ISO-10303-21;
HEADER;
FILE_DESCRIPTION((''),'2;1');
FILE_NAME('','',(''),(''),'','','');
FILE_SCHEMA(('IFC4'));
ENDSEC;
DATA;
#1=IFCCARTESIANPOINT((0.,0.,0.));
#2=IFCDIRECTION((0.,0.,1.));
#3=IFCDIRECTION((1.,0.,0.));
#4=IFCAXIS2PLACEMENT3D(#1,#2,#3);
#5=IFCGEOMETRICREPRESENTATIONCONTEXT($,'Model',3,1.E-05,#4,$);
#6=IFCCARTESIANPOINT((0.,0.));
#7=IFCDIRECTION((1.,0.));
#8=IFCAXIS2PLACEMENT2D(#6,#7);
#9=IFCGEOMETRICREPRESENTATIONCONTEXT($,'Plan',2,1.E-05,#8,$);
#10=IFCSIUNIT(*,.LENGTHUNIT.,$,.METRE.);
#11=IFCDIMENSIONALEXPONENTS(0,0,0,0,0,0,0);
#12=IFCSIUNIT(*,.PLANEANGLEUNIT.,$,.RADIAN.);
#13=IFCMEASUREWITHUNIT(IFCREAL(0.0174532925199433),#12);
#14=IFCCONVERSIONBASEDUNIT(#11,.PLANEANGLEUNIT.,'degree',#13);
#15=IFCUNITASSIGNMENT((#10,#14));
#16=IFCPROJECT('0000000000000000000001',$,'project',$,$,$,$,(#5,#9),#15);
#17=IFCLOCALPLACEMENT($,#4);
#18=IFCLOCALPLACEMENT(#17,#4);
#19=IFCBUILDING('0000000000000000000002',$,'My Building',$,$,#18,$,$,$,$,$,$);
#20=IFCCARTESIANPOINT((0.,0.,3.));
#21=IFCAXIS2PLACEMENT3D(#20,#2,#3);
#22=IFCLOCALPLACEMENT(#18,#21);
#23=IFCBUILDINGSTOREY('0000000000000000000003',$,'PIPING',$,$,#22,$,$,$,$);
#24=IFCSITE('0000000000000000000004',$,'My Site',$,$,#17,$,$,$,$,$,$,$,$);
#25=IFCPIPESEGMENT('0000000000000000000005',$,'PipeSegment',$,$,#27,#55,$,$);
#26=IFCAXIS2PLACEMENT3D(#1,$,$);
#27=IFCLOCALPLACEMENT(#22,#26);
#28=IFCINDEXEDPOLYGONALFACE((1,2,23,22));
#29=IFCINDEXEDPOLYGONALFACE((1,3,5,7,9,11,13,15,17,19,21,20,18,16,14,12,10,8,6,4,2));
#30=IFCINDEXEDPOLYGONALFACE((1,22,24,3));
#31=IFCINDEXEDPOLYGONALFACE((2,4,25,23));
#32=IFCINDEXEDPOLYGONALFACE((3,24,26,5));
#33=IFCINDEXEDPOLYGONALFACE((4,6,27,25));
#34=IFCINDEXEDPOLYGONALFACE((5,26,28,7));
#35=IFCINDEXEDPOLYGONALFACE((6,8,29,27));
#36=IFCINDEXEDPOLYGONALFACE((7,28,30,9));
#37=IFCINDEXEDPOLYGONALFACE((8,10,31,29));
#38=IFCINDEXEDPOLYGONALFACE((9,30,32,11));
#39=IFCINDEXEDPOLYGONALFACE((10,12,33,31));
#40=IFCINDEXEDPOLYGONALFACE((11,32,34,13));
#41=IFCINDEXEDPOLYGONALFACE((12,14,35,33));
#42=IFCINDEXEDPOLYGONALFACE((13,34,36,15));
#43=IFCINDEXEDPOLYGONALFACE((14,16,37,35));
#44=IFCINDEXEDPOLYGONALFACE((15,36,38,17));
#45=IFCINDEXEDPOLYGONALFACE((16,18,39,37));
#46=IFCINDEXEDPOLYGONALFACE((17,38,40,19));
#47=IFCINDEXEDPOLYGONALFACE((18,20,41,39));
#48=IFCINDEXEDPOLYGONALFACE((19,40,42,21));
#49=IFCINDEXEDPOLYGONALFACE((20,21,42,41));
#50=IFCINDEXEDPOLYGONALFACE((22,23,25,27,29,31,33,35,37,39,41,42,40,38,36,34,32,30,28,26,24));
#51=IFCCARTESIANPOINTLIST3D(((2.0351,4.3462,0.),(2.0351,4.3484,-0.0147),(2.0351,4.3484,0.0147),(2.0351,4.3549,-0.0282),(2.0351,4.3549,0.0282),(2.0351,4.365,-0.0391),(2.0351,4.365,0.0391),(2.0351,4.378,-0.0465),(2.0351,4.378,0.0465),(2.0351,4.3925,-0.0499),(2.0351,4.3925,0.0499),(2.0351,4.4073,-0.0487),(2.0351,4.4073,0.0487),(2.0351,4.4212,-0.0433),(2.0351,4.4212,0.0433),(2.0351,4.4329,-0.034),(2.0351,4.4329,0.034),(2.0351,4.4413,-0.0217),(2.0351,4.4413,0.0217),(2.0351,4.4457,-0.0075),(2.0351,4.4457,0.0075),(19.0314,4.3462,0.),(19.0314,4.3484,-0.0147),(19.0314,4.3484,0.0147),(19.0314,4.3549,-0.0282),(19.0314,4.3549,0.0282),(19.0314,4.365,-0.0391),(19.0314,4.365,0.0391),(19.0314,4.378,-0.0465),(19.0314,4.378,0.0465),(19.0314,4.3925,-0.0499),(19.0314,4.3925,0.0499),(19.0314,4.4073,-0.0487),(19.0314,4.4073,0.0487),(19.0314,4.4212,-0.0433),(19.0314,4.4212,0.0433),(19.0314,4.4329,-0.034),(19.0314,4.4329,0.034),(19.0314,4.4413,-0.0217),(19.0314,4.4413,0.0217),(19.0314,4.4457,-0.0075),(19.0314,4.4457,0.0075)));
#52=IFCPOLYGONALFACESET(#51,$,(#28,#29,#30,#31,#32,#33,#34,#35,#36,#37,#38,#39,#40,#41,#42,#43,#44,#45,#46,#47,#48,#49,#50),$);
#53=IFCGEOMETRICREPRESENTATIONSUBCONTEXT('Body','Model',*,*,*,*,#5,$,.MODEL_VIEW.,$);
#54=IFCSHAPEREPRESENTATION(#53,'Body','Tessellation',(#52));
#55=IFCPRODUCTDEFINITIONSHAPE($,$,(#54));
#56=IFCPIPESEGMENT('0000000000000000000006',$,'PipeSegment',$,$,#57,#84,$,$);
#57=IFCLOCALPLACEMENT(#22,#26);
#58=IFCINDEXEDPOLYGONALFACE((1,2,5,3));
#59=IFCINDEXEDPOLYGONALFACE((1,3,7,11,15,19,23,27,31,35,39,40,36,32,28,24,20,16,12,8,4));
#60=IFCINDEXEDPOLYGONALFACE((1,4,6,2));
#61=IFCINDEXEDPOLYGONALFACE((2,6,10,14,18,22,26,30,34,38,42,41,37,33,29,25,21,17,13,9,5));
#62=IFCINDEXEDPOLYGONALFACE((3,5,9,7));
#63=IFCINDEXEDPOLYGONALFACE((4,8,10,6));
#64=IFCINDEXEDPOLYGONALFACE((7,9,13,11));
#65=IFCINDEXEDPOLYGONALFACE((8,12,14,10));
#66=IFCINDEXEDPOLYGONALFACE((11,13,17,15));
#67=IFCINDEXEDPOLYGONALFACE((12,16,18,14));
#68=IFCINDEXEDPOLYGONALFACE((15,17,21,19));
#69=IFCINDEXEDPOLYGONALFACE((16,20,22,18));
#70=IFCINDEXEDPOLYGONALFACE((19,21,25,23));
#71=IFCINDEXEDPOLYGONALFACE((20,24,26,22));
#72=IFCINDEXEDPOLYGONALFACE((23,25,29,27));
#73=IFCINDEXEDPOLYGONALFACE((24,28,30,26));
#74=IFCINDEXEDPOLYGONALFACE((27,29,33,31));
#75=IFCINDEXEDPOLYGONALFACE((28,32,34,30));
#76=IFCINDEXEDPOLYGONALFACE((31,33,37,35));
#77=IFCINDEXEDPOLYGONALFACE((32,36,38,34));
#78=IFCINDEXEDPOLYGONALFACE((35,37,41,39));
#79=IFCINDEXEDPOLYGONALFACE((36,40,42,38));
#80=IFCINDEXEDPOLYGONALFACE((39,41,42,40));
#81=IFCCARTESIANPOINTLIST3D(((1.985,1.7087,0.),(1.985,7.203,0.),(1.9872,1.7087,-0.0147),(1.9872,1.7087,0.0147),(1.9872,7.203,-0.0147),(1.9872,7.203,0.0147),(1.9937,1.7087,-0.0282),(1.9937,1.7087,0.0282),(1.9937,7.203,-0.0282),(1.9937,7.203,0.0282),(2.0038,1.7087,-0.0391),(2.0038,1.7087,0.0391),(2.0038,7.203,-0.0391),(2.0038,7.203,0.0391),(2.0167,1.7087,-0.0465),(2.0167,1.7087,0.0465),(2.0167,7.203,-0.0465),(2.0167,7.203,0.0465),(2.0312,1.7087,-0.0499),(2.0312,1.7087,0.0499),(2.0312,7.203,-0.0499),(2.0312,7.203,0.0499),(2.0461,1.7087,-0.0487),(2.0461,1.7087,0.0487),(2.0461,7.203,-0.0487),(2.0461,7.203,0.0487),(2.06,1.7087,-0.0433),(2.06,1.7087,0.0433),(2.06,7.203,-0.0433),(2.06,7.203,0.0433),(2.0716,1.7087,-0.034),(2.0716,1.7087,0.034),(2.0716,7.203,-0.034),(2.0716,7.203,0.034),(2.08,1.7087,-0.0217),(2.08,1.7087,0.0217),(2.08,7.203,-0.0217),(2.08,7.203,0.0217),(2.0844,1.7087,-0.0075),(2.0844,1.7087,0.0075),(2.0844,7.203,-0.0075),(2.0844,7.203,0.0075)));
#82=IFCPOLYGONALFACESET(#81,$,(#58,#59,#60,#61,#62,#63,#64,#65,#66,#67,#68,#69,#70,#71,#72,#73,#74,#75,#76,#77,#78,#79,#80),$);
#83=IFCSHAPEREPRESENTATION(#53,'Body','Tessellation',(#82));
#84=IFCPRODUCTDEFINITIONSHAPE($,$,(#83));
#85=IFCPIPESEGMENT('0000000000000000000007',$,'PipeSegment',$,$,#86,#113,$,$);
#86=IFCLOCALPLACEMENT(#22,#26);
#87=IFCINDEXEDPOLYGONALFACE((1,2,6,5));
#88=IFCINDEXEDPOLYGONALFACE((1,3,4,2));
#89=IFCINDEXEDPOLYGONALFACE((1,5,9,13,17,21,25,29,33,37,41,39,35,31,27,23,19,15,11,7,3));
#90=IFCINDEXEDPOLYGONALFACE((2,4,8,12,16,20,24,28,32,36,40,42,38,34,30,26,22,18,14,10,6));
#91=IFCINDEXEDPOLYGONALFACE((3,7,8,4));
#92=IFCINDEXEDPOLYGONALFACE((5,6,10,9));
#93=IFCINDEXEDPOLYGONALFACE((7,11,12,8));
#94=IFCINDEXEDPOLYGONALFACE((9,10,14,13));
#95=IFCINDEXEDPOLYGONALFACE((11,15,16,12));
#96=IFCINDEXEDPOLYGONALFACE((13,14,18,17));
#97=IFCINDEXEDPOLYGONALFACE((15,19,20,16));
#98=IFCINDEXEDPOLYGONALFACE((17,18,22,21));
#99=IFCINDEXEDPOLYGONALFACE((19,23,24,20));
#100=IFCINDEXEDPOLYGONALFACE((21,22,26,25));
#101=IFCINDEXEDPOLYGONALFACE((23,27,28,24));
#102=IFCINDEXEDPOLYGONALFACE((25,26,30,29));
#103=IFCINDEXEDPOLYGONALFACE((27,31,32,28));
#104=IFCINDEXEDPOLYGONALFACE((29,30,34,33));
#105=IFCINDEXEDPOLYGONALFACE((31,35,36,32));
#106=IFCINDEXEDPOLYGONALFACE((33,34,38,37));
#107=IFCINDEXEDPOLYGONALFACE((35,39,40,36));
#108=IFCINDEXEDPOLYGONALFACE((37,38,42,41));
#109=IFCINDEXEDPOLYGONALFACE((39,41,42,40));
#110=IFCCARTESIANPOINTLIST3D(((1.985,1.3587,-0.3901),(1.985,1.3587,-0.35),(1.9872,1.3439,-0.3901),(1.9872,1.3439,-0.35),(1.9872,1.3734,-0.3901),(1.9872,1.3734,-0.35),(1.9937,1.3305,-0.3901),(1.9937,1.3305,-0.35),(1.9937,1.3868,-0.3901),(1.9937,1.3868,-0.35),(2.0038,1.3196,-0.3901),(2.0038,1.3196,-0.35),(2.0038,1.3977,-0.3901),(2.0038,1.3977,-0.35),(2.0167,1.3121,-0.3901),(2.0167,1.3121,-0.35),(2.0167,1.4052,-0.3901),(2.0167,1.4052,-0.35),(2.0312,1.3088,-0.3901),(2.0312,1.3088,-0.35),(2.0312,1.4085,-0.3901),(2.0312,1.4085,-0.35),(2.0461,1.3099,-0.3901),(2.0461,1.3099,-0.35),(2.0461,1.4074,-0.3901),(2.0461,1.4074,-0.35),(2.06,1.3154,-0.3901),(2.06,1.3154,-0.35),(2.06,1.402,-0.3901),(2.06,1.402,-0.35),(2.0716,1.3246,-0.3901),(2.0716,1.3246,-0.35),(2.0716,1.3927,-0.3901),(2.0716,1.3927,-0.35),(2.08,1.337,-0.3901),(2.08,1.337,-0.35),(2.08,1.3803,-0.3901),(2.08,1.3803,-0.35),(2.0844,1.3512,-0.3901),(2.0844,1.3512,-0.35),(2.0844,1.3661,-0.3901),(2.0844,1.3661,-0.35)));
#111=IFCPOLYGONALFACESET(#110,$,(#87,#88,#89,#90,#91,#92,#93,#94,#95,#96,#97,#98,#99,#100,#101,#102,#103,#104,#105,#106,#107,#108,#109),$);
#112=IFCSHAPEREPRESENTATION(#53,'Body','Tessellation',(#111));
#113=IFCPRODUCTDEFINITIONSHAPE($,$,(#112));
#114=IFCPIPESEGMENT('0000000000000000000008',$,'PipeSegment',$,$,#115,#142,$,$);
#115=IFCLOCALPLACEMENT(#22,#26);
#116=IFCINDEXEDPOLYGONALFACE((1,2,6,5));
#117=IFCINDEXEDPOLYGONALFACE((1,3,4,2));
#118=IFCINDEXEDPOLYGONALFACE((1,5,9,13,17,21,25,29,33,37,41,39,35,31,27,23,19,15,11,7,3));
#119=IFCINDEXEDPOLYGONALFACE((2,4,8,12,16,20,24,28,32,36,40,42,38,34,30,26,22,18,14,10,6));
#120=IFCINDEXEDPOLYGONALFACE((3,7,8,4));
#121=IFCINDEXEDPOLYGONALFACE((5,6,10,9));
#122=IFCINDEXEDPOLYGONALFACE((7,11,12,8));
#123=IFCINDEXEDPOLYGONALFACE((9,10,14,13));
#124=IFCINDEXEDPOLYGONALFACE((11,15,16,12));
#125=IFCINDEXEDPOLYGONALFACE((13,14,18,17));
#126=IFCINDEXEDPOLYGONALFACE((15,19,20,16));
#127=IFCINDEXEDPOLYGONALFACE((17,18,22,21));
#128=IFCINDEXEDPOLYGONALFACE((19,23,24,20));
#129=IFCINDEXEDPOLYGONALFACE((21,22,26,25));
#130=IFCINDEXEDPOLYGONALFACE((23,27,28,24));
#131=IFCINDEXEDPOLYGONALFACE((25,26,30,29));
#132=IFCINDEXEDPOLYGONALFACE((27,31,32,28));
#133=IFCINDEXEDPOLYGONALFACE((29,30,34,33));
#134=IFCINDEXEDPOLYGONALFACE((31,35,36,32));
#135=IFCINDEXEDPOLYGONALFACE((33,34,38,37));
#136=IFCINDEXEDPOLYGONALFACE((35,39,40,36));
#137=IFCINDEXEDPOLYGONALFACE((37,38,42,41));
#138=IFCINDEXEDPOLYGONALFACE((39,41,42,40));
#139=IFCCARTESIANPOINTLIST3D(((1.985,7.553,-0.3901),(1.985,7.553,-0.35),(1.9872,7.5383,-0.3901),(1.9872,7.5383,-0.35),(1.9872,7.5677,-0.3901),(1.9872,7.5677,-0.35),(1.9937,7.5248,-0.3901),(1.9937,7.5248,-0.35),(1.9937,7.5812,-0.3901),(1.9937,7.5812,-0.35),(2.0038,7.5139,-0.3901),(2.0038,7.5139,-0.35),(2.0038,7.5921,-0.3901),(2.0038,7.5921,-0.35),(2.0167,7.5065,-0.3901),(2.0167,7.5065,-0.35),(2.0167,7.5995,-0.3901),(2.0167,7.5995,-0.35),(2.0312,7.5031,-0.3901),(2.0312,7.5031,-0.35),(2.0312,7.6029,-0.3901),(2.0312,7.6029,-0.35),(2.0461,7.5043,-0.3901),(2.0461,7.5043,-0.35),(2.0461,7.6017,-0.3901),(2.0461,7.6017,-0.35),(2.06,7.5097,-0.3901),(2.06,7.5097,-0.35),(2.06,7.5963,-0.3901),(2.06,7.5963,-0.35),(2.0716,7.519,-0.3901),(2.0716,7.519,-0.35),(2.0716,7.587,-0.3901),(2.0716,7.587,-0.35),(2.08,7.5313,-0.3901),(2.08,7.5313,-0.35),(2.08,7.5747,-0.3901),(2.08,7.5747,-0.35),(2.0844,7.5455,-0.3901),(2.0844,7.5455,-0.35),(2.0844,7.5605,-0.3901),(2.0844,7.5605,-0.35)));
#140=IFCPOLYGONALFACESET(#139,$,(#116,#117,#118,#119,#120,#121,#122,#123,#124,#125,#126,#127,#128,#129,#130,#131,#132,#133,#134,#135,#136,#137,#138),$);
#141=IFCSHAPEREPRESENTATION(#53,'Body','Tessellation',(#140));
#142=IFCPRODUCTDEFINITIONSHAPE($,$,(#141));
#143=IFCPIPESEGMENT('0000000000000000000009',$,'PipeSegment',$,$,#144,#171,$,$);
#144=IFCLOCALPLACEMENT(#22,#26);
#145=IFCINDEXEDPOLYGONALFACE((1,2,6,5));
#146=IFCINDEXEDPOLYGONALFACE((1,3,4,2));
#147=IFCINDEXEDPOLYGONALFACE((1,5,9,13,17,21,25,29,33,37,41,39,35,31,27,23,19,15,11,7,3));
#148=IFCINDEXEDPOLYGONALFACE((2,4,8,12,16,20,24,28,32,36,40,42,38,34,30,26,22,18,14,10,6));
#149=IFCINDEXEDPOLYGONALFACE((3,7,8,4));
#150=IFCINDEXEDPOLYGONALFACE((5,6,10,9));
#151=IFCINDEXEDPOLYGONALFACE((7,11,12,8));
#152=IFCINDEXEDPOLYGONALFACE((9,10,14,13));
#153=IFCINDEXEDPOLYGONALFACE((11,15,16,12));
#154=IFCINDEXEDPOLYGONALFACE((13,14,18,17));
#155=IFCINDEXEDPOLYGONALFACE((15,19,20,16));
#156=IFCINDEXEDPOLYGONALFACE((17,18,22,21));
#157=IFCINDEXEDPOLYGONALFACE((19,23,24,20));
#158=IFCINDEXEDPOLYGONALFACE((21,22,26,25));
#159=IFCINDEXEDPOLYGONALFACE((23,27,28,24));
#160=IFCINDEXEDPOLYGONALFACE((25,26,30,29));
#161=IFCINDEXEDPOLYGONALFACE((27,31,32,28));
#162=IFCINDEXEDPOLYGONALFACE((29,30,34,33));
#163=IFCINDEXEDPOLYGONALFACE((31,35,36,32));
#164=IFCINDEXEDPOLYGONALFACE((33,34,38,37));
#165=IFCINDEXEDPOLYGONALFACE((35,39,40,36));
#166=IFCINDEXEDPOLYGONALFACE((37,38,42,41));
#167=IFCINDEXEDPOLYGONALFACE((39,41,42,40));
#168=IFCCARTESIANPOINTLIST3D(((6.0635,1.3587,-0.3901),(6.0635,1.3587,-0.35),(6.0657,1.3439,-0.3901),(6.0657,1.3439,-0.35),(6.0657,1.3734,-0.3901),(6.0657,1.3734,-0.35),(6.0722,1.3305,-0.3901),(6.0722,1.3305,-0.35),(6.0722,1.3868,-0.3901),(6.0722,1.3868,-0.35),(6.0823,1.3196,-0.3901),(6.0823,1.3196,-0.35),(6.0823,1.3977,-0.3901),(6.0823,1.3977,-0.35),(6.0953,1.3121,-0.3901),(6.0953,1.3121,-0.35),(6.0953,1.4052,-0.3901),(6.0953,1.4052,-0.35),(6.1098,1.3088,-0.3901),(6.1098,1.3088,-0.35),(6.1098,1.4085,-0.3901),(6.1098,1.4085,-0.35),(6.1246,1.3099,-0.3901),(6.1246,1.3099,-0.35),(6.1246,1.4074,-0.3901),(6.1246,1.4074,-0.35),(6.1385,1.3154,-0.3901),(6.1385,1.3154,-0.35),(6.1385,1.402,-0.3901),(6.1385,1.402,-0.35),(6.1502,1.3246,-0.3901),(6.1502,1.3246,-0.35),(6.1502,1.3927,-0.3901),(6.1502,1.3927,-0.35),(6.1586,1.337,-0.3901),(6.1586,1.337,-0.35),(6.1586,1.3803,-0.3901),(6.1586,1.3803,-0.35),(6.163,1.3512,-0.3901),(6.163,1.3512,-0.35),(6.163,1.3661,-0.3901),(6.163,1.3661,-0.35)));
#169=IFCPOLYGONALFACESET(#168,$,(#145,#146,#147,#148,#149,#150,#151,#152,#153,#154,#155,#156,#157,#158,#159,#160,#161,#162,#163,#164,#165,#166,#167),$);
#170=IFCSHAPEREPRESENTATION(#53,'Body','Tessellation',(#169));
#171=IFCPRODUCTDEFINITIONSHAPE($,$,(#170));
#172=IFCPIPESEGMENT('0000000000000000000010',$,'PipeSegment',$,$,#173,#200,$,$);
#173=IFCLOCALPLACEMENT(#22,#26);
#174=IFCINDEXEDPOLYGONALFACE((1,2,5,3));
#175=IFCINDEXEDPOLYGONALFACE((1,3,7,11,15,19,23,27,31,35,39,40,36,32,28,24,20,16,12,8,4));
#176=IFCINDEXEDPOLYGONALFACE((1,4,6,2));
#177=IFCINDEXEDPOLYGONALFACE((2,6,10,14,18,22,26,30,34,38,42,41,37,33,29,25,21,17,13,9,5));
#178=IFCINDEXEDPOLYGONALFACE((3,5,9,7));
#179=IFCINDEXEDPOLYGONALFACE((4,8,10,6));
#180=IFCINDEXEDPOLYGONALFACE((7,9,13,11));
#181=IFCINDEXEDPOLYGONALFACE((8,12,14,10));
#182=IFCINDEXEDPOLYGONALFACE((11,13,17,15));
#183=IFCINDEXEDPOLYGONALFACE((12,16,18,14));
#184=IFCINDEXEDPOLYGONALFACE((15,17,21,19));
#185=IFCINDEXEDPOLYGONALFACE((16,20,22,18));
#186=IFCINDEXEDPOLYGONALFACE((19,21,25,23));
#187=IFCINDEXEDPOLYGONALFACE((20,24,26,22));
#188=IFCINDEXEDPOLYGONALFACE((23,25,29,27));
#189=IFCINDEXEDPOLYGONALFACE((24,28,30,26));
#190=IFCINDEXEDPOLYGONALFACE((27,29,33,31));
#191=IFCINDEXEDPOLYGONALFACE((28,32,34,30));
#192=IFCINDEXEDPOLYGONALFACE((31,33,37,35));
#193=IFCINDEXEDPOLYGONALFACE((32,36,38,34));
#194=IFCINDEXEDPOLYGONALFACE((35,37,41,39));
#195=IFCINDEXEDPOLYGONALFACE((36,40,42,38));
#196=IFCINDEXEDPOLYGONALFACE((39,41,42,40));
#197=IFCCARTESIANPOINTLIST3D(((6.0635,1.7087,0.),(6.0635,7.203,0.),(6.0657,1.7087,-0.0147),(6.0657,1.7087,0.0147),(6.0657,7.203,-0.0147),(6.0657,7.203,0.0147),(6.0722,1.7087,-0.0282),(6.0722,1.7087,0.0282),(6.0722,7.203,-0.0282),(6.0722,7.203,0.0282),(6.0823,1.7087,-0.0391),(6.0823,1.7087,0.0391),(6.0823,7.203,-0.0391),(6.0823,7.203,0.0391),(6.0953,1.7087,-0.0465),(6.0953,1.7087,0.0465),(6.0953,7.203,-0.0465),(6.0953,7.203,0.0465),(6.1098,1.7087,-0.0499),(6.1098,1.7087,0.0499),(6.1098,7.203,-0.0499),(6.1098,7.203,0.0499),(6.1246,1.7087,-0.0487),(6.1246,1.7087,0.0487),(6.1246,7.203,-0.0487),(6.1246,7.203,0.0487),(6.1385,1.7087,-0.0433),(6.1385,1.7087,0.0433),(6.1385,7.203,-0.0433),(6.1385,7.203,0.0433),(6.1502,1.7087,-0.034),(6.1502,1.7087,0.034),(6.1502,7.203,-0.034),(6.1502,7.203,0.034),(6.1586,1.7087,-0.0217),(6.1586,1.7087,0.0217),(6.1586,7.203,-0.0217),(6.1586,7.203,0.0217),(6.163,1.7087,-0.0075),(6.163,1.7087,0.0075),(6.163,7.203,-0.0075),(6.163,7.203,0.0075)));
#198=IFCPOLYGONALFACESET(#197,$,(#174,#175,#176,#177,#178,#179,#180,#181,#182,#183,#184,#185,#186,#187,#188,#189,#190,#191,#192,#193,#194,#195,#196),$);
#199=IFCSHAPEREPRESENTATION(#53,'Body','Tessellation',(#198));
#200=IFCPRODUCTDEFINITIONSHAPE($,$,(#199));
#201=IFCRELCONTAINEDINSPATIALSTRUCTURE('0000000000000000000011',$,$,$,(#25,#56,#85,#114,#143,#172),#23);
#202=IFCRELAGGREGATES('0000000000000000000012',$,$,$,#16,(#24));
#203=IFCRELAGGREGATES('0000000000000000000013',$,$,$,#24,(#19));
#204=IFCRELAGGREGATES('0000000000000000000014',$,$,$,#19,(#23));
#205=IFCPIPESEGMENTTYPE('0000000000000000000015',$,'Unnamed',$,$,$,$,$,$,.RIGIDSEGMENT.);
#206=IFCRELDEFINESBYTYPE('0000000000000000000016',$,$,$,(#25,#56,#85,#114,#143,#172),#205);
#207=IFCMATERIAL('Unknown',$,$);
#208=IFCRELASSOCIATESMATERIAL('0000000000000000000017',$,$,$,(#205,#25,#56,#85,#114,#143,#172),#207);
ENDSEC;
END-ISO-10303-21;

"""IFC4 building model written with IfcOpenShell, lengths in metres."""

from ifc_helpers import new_model, entity, si_unit, converted_unit, frame, origin_with_axes, origin_2d_with_axis, place, context, subcontext, project, spatial, circle, extrude, material, material_profile, profile_set, profile_usage, type_object, element, save


model = new_model("IFC4")

# Units and contexts
model_context = context("Model", 3, precision=1e-05, world=origin_with_axes())
plan_context = context("Plan", 2, precision=1e-05, world=origin_2d_with_axis())
body_context = subcontext(model_context, "Body", "Model", "MODEL_VIEW")
ifc_project = project(units=[si_unit("LENGTHUNIT", "METRE"), converted_unit("PLANEANGLEUNIT", "degree", entity("IfcReal", 0.0174532925199433), si_unit("PLANEANGLEUNIT", "RADIAN"), dimensions=[0, 0, 0, 0, 0, 0, 0])], contexts=[model_context, plan_context])

# Site, building, storey
site_placement = place(None, origin_with_axes())
site = spatial("IfcSite", under=ifc_project, at=site_placement, Name="My Site")
building_placement = place(site_placement, origin_with_axes())
building = spatial("IfcBuilding", under=site, at=building_placement, Name="My Building")
storey_placement = place(building_placement, frame((0.0, 0.0, 3.0), z_axis=(0.0, 0.0, 1.0), x_axis=(1.0, 0.0, 0.0)))
storey = spatial("IfcBuildingStorey", under=building, at=storey_placement, Name="PIPING")

# Pipe segments
ifc_material = material(Name="Unknown")
ifc_material_profile = material_profile(ifc_material, circle(Radius=0.05))
ifc_profile_set = profile_set([ifc_material_profile])
ifc_profile_usage_1 = profile_usage(ifc_profile_set, cardinal=5)
pipe_segment_type = type_object("IfcPipeSegmentType", Name="Unnamed", PredefinedType="RIGIDSEGMENT", material=ifc_profile_set)
pipe_segment_1_placement = place(storey_placement, frame((19.0314, 4.3962, 0.0), z_axis=(-1.0, 0.0, 0.0), x_axis=(0.0, -1.0, 0.0)))
element("IfcPipeSegment", 1, at=pipe_segment_1_placement, inside=storey, type_object=pipe_segment_type, material=ifc_profile_usage_1, Name="PipeSegment", context=body_context, shape_type="SweptSolid", body=[
    extrude(circle(Radius=0.05), origin_with_axes(), (0.0, 0.0, 1.0), 16.9963),
])
ifc_profile_usage_2 = profile_usage(ifc_profile_set, cardinal=5)
pipe_segment_2_placement = place(storey_placement, frame((2.035, 1.7087, 0.0), z_axis=(0.0, 1.0, 0.0), x_axis=(-1.0, 0.0, 0.0)))
element("IfcPipeSegment", 2, at=pipe_segment_2_placement, inside=storey, type_object=pipe_segment_type, material=ifc_profile_usage_2, Name="PipeSegment", context=body_context, shape_type="SweptSolid", body=[
    extrude(circle(Radius=0.05), origin_with_axes(), (0.0, 0.0, 1.0), 5.4943),
])
ifc_profile_usage_3 = profile_usage(ifc_profile_set, cardinal=5)
pipe_segment_3_placement = place(storey_placement, frame((2.035, 1.3587, -0.35), z_axis=(0.0, 0.0, -1.0), x_axis=(-1.0, 0.0, 0.0)))
element("IfcPipeSegment", 3, at=pipe_segment_3_placement, inside=storey, type_object=pipe_segment_type, material=ifc_profile_usage_3, Name="PipeSegment", context=body_context, shape_type="SweptSolid", body=[
    extrude(circle(Radius=0.05), origin_with_axes(), (0.0, 0.0, 1.0), 0.0401),
])
ifc_profile_usage_4 = profile_usage(ifc_profile_set, cardinal=5)
pipe_segment_4_placement = place(storey_placement, frame((2.035, 7.553, -0.35), z_axis=(0.0, 0.0, -1.0), x_axis=(-1.0, 0.0, 0.0)))
element("IfcPipeSegment", 4, at=pipe_segment_4_placement, inside=storey, type_object=pipe_segment_type, material=ifc_profile_usage_4, Name="PipeSegment", context=body_context, shape_type="SweptSolid", body=[
    extrude(circle(Radius=0.05), origin_with_axes(), (0.0, 0.0, 1.0), 0.0401),
])
ifc_profile_usage_5 = profile_usage(ifc_profile_set, cardinal=5)
pipe_segment_5_placement = place(storey_placement, frame((6.1135, 1.3587, -0.35), z_axis=(0.0, 0.0, -1.0), x_axis=(-1.0, 0.0, 0.0)))
element("IfcPipeSegment", 5, at=pipe_segment_5_placement, inside=storey, type_object=pipe_segment_type, material=ifc_profile_usage_5, Name="PipeSegment", context=body_context, shape_type="SweptSolid", body=[
    extrude(circle(Radius=0.05), origin_with_axes(), (0.0, 0.0, 1.0), 0.0401),
])
ifc_profile_usage_6 = profile_usage(ifc_profile_set, cardinal=5)
pipe_segment_6_placement = place(storey_placement, frame((6.1135, 1.7087, 0.0), z_axis=(0.0, 1.0, 0.0), x_axis=(-1.0, 0.0, 0.0)))
element("IfcPipeSegment", 6, at=pipe_segment_6_placement, inside=storey, type_object=pipe_segment_type, material=ifc_profile_usage_6, Name="PipeSegment", context=body_context, shape_type="SweptSolid", body=[
    extrude(circle(Radius=0.05), origin_with_axes(), (0.0, 0.0, 1.0), 5.4943),
])

save(model, "model.ifc")
